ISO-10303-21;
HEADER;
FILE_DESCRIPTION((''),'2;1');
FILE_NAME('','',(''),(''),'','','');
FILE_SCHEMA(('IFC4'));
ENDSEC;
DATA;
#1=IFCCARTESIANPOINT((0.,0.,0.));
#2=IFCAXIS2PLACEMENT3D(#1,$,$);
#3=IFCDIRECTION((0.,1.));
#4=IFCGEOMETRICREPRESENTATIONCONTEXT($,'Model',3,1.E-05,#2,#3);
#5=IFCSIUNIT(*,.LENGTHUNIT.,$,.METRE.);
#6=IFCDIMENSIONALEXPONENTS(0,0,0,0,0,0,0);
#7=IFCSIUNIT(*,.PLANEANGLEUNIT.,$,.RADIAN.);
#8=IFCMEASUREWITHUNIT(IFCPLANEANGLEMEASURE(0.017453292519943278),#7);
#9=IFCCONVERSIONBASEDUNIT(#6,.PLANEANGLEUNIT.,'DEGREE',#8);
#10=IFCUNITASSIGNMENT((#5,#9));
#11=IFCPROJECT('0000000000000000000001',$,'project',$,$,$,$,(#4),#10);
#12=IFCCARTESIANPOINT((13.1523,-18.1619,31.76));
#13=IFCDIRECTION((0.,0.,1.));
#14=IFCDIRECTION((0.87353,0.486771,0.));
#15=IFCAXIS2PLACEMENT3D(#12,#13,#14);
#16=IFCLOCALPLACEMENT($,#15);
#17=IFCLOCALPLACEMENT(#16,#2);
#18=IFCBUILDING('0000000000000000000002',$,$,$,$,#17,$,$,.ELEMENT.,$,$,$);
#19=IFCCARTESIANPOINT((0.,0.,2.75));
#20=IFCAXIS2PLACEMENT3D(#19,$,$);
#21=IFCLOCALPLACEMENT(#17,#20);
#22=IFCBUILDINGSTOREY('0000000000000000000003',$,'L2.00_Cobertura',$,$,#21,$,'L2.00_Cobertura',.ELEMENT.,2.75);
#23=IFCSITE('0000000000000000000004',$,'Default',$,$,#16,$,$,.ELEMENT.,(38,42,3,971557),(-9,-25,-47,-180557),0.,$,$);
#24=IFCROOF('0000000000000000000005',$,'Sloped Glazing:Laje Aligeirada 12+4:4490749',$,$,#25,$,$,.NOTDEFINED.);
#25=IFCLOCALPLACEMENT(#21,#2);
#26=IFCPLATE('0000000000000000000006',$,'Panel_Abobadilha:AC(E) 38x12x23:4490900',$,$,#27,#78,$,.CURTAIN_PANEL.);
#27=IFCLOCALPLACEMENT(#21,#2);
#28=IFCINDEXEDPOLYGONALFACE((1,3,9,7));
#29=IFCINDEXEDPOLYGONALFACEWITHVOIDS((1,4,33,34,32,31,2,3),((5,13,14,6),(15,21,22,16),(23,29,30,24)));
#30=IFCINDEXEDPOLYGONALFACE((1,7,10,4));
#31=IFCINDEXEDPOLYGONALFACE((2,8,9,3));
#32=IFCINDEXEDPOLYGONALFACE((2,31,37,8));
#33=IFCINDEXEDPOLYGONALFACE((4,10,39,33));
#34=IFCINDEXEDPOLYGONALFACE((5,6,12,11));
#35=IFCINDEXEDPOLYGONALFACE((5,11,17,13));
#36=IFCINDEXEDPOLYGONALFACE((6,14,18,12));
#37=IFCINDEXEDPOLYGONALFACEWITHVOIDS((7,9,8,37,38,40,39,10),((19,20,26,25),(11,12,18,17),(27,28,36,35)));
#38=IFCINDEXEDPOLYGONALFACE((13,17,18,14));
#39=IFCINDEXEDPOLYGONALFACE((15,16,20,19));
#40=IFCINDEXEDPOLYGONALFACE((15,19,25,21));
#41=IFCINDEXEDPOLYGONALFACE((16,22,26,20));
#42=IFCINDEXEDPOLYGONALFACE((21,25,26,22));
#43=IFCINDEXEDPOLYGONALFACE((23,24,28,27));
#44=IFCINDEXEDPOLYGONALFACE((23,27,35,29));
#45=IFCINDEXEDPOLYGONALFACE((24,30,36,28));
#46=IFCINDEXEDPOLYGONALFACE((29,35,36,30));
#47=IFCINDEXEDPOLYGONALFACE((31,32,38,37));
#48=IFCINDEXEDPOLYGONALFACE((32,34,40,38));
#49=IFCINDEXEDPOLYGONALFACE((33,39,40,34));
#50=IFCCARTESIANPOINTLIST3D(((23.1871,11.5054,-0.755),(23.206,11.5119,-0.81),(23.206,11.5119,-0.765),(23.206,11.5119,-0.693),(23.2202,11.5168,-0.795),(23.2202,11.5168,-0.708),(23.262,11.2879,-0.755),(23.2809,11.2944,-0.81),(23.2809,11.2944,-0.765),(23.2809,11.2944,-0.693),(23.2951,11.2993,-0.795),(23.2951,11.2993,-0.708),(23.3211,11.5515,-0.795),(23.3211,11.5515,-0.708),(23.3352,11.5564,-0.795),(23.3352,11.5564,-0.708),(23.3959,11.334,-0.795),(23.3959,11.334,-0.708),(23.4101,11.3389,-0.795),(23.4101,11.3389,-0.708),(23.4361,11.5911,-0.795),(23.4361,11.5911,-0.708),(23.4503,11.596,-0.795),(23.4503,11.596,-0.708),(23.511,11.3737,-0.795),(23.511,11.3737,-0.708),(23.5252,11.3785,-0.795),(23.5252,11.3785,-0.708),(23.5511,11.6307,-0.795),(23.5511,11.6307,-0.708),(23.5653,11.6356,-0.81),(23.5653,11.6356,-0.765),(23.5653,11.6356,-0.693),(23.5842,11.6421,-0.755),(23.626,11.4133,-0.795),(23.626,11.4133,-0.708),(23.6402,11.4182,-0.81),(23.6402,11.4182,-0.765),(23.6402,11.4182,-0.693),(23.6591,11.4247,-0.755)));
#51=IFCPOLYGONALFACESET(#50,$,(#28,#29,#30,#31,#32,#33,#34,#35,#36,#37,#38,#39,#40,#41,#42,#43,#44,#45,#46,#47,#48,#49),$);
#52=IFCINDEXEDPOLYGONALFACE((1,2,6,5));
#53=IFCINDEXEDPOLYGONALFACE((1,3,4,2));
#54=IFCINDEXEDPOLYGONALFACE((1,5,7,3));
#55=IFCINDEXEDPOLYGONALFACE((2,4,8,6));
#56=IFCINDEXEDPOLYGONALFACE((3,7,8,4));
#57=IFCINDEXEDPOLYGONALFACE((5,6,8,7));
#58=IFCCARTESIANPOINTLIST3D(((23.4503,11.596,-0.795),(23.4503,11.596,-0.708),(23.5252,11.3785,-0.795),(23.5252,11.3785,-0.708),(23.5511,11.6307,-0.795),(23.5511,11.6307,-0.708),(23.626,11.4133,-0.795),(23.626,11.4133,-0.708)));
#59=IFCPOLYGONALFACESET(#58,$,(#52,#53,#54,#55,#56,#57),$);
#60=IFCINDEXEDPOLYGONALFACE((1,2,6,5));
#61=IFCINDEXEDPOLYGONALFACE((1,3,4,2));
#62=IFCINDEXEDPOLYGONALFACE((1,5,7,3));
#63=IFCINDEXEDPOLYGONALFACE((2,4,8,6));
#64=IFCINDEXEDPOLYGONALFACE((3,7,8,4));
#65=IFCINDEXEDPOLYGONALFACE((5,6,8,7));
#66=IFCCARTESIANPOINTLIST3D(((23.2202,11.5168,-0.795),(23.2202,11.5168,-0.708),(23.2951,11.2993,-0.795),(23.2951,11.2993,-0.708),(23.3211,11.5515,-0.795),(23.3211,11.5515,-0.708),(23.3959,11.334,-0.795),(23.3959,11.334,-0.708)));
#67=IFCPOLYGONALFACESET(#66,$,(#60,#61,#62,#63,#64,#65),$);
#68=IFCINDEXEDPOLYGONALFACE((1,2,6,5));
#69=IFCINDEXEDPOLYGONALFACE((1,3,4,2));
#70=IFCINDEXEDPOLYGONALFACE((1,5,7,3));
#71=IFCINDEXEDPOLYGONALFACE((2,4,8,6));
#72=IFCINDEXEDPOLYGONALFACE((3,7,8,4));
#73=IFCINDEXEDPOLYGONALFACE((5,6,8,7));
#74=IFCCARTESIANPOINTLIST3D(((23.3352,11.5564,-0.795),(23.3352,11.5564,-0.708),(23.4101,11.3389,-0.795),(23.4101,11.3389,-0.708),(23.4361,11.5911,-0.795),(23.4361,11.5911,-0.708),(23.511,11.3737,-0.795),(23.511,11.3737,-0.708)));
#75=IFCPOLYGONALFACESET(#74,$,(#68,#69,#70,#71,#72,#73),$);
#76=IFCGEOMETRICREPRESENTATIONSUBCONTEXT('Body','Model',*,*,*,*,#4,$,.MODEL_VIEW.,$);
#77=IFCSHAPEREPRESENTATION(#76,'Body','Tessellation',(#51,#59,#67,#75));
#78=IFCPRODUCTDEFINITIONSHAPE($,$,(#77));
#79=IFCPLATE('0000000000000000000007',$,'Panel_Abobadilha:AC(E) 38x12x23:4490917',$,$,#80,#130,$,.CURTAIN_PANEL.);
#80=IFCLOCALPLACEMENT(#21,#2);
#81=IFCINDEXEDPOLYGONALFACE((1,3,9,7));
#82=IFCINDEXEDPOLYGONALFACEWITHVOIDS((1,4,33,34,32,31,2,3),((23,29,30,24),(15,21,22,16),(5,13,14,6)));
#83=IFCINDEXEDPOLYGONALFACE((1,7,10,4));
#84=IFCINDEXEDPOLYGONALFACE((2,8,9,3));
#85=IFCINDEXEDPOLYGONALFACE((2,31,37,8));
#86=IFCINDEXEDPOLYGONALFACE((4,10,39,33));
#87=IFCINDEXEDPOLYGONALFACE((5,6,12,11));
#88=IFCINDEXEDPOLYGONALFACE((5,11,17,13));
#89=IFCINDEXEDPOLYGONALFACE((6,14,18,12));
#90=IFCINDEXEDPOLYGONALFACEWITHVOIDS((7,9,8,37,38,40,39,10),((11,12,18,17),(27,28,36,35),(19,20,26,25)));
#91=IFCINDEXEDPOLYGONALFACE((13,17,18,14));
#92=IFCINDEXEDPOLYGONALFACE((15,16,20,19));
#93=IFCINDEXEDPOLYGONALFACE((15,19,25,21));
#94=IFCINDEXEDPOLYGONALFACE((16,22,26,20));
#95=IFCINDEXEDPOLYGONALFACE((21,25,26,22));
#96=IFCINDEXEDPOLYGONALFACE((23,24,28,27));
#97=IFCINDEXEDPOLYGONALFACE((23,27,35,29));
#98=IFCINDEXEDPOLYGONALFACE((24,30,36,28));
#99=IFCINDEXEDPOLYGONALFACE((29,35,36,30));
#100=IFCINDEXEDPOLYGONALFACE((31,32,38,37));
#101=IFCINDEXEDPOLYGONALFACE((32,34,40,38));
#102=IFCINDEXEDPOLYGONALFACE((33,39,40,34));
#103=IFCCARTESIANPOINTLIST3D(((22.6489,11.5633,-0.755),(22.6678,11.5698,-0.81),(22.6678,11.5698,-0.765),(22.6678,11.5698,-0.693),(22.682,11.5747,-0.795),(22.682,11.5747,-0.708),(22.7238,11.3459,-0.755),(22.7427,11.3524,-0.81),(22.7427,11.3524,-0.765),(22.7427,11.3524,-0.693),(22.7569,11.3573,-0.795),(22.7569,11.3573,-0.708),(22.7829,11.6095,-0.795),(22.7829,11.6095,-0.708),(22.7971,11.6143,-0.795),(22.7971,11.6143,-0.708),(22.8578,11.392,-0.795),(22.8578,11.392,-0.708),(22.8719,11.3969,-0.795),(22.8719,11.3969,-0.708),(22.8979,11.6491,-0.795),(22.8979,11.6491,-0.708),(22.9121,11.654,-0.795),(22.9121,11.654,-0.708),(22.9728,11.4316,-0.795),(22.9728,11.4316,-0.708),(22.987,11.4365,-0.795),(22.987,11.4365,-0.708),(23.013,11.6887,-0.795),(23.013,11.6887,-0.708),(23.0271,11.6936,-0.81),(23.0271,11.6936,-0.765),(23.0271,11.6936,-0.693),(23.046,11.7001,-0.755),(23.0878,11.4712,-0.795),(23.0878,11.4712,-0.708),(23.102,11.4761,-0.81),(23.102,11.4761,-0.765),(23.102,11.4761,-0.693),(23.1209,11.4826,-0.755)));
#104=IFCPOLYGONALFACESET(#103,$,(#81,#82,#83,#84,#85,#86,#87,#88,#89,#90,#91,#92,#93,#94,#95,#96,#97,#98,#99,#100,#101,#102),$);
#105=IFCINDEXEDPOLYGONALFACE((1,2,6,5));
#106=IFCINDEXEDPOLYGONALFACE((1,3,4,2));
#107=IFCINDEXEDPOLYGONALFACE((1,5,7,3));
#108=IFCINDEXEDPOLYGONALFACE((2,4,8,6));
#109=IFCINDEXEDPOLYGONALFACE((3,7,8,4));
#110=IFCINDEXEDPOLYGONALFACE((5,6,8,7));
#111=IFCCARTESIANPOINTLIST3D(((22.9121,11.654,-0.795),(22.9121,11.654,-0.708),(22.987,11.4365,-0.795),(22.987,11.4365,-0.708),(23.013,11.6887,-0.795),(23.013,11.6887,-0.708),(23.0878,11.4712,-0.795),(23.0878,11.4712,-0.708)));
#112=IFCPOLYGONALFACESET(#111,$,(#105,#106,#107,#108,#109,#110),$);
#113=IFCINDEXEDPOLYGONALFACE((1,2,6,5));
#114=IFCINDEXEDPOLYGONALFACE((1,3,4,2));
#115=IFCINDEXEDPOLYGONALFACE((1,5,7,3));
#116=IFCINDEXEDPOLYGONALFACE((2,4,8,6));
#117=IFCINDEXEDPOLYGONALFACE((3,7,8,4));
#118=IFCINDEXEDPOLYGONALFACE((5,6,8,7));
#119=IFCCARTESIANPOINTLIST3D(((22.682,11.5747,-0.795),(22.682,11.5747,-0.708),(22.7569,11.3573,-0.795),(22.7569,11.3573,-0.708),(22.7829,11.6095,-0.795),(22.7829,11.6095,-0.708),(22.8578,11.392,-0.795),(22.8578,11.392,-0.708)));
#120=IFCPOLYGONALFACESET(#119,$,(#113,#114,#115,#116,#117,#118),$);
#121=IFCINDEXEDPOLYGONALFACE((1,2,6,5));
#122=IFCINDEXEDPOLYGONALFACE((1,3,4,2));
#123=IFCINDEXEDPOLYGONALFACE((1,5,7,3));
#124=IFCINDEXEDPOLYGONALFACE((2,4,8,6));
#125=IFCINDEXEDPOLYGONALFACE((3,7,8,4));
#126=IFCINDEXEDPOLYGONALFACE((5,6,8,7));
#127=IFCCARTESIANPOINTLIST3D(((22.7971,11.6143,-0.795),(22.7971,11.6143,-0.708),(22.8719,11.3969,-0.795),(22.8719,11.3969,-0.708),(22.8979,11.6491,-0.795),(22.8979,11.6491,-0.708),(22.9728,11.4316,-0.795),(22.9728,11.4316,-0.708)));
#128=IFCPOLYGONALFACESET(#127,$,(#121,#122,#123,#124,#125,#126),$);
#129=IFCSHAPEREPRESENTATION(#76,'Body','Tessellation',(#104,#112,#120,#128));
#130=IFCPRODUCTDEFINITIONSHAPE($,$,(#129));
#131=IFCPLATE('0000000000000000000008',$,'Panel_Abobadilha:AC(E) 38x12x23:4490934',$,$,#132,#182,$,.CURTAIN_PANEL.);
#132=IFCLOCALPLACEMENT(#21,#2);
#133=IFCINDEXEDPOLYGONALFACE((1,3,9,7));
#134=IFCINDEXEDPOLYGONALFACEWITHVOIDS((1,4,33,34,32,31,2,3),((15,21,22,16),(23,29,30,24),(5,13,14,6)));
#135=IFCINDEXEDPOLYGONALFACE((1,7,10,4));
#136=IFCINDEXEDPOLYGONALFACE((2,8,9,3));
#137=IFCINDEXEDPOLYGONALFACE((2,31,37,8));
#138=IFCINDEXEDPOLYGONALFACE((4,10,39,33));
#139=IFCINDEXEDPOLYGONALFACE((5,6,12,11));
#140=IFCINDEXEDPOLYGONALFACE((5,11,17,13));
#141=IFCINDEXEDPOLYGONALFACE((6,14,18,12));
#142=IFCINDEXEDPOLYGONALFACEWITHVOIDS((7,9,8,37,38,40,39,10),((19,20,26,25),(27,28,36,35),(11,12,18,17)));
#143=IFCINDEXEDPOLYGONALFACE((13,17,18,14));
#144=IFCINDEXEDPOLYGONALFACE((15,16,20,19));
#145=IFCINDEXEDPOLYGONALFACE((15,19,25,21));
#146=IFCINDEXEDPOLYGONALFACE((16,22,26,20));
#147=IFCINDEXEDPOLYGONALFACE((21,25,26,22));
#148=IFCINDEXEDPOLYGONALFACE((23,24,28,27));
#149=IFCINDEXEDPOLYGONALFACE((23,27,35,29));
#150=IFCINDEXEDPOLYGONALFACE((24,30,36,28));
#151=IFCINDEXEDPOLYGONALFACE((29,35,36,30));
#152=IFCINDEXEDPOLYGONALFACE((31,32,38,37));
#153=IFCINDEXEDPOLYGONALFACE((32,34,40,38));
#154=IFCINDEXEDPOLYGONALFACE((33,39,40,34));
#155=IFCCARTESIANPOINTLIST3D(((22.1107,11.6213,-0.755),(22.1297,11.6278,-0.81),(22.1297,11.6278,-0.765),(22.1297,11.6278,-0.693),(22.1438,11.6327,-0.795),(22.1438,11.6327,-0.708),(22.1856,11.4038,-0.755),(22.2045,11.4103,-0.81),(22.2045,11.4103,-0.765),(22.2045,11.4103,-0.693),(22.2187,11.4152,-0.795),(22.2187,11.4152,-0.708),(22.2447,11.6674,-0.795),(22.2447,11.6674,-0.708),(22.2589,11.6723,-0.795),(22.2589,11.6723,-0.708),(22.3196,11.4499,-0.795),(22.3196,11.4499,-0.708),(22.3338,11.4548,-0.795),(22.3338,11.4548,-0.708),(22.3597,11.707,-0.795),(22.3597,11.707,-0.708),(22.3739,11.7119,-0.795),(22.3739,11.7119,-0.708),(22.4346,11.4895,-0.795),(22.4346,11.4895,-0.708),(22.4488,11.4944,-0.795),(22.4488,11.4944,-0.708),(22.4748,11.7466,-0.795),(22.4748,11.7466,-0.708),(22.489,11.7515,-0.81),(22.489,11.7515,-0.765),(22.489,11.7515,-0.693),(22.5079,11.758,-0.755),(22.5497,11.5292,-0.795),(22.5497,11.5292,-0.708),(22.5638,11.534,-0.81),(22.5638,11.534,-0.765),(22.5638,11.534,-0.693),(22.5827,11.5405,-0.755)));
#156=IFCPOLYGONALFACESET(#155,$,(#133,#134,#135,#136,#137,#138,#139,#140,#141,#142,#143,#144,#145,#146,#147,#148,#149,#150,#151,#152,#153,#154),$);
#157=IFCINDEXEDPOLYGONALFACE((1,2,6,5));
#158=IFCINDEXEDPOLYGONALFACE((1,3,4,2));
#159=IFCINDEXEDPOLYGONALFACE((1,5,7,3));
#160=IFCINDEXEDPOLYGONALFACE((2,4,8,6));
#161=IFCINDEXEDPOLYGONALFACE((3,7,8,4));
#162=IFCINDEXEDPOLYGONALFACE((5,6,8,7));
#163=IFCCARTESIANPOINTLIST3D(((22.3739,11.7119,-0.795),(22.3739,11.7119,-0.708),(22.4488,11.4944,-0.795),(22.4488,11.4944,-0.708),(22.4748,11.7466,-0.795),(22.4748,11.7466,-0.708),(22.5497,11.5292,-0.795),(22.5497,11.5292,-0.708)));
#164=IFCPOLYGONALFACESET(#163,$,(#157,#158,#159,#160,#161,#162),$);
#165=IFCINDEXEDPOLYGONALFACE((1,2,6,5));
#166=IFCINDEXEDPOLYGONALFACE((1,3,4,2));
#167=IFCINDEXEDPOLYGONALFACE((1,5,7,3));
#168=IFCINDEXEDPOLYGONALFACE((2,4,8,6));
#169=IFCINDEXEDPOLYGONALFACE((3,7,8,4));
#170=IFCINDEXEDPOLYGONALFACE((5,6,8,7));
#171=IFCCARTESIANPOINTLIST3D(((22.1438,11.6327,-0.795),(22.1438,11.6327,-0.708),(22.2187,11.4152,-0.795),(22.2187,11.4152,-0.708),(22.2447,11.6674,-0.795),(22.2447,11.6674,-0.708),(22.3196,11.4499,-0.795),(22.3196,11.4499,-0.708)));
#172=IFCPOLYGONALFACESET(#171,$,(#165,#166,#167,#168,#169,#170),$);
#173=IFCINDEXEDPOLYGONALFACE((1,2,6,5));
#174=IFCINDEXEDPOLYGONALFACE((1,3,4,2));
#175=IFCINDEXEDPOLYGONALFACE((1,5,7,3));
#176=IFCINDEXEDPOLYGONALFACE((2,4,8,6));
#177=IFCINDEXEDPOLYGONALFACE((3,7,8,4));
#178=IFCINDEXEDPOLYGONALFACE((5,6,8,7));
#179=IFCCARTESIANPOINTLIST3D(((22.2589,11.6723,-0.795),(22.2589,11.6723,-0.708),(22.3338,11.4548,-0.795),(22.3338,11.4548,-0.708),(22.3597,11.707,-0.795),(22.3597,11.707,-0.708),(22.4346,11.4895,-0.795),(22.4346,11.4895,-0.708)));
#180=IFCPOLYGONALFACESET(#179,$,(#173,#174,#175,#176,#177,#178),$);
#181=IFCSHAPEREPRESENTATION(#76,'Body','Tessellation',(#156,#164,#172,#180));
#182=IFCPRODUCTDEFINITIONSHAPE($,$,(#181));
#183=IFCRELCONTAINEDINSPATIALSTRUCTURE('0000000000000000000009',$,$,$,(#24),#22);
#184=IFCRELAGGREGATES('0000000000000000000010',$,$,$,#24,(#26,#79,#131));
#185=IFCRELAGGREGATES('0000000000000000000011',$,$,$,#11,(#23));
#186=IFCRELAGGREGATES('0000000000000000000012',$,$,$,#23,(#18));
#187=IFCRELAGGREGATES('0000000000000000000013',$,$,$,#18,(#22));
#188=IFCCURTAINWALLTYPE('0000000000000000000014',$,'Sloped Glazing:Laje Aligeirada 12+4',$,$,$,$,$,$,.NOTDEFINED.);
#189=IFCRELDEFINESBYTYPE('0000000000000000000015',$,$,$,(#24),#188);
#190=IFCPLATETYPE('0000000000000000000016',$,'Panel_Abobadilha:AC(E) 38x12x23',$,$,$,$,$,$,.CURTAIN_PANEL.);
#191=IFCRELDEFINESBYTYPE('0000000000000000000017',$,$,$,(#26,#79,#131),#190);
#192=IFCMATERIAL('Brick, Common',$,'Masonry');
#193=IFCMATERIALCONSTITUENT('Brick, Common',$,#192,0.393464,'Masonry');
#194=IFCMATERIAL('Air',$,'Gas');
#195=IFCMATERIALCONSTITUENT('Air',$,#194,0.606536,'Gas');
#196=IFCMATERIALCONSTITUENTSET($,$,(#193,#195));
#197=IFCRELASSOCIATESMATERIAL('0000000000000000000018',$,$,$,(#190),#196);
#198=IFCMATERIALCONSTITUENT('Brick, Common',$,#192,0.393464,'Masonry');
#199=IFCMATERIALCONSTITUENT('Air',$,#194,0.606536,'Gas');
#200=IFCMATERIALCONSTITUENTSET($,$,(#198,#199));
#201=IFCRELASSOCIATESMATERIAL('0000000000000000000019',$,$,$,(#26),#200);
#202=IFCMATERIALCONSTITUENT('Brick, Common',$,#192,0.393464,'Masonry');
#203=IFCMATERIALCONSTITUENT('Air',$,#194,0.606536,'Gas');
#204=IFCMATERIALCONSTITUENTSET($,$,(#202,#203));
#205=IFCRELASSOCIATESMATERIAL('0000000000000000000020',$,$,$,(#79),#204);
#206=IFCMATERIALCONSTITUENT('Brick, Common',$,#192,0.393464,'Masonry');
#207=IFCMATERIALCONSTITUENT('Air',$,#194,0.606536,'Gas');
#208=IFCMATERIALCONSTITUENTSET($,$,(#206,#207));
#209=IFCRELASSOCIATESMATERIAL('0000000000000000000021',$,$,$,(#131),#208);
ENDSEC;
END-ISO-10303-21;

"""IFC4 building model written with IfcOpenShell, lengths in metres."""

from ifc_helpers import new_model, entity, si_unit, converted_unit, direction, frame, origin, place, context, subcontext, project, spatial, indexed_curve, outline, extrude, source, transform, mapped, material, constituent, constituent_set, type_object, type_shapes, element, aggregate, save


model = new_model("IFC4")

# Units and contexts
model_context = context("Model", 3, precision=1e-05, world=origin(), true_north=direction((0.0, 1.0)))
body_context = subcontext(model_context, "Body", "Model", "MODEL_VIEW")
ifc_project = project(units=[si_unit("LENGTHUNIT", "METRE"), converted_unit("PLANEANGLEUNIT", "DEGREE", entity("IfcPlaneAngleMeasure", 0.017453292519943278), si_unit("PLANEANGLEUNIT", "RADIAN"), dimensions=[0, 0, 0, 0, 0, 0, 0])], contexts=[model_context])

# Site, building, storey
site_placement = place(None, frame((13.1523, -18.1619, 31.76), z_axis=(0.0, 0.0, 1.0), x_axis=(0.87353, 0.486771, 0.0)))
site = spatial("IfcSite", under=ifc_project, at=site_placement, Name="Default", CompositionType="ELEMENT", RefLatitude=(38, 42, 3, 971557), RefLongitude=(-9, -25, -47, -180557), RefElevation=0.0)
building_placement = place(site_placement, origin())
building = spatial("IfcBuilding", under=site, at=building_placement, CompositionType="ELEMENT")
storey_placement = place(building_placement, frame((0.0, 0.0, 2.75)))
storey = spatial("IfcBuildingStorey", under=building, at=storey_placement, Name="L2.00_Cobertura", LongName="L2.00_Cobertura", CompositionType="ELEMENT", Elevation=2.75)

# Roof, plates
curtain_wall_type = type_object("IfcCurtainWallType", Name="Sloped Glazing:Laje Aligeirada 12+4", PredefinedType="NOTDEFINED")
roof_placement = place(storey_placement, frame((0.0, 0.0, -2.75)))
roof = element("IfcRoof", 1, at=roof_placement, inside=storey, type_object=curtain_wall_type, Name="Sloped Glazing:Laje Aligeirada 12+4:4490749", PredefinedType="NOTDEFINED")
ifc_material_1 = material(Name="Brick, Common", Category="Masonry")
ifc_material_2 = material(Name="Air", Category="Gas")
ifc_constituent_1 = constituent(ifc_material_1, Name="Brick, Common", Category="Masonry", fraction=0.393464)
ifc_constituent_2 = constituent(ifc_material_2, Name="Air", Category="Gas", fraction=0.606536)
ifc_constituent_set_1 = constituent_set(constituents=[ifc_constituent_1, ifc_constituent_2])
plate_type_1 = type_object("IfcPlateType", Name="Panel_Abobadilha:AC(E) 38x12x23", PredefinedType="CURTAIN_PANEL", material=ifc_constituent_set_1)
shared_shape_1 = source(origin(), body_context, "Body", "SweptSolid", [
    extrude(outline(indexed_curve([(-0.19, -0.0543), (0.19, -0.0543), (0.19, -0.0093), (0.21, 0.0007), (0.19, 0.0628), (-0.19, 0.0628), (-0.21, 0.0007), (-0.19, -0.0093), (-0.19, -0.0543)], self_intersect=False), holes=[indexed_curve([(-0.0683, 0.0477), (-0.0683, -0.0393), (-0.175, -0.0393), (-0.175, 0.0477), (-0.0683, 0.0477)], self_intersect=False), indexed_curve([(0.0533, 0.0477), (0.0533, -0.0393), (-0.0533, -0.0393), (-0.0533, 0.0477), (0.0533, 0.0477)], self_intersect=False), indexed_curve([(0.175, 0.0477), (0.175, -0.0393), (0.0683, -0.0393), (0.0683, 0.0477), (0.175, 0.0477)], self_intersect=False)]), frame((0.0, 0.0543, 0.0)), (0.0, 0.0, 1.0), 0.23),
    extrude(outline(indexed_curve([(-0.0533, -0.0435), (0.0533, -0.0435), (0.0533, 0.0435), (-0.0533, 0.0435), (-0.0533, -0.0435)], self_intersect=False)), frame((0.1217, 0.0585, 0.0), z_axis=(0.0, 0.0, 1.0), x_axis=(-1.0, 0.0, 0.0)), (0.0, 0.0, 1.0), 0.23),
    extrude(outline(indexed_curve([(-0.0533, -0.0435), (0.0533, -0.0435), (0.0533, 0.0435), (-0.0533, 0.0435), (-0.0533, -0.0435)], self_intersect=False)), frame((-0.1217, 0.0585, 0.0), z_axis=(0.0, 0.0, 1.0), x_axis=(-1.0, 0.0, 0.0)), (0.0, 0.0, 1.0), 0.23),
    extrude(outline(indexed_curve([(-0.0533, -0.0435), (0.0533, -0.0435), (0.0533, 0.0435), (-0.0533, 0.0435), (-0.0533, -0.0435)], self_intersect=False)), frame((0.0, 0.0585, 0.0), z_axis=(0.0, 0.0, 1.0), x_axis=(-1.0, 0.0, 0.0)), (0.0, 0.0, 1.0), 0.23),
])
type_shapes(plate_type_1, [shared_shape_1])
ifc_constituent_3 = constituent(ifc_material_1, Name="Brick, Common", Category="Masonry", fraction=0.393464)
ifc_constituent_4 = constituent(ifc_material_2, Name="Air", Category="Gas", fraction=0.606536)
ifc_constituent_set_2 = constituent_set(constituents=[ifc_constituent_3, ifc_constituent_4])
plate_1_placement = place(roof_placement, frame((23.3857, 11.5738, 1.94), z_axis=(0.325568, -0.945519, 0.0), x_axis=(0.945519, 0.325568, 0.0)))
plate_1 = element("IfcPlate", 2, at=plate_1_placement, type_object=plate_type_1, material=ifc_constituent_set_2, Name="Panel_Abobadilha:AC(E) 38x12x23:4490900", PredefinedType="CURTAIN_PANEL", context=body_context, shape_type="MappedRepresentation", body=[
    mapped(shared_shape_1, transform((0.0, 0.0, 0.0), scale=1.0)),
])
ifc_constituent_5 = constituent(ifc_material_1, Name="Brick, Common", Category="Masonry", fraction=0.393464)
ifc_constituent_6 = constituent(ifc_material_2, Name="Air", Category="Gas", fraction=0.606536)
ifc_constituent_set_3 = constituent_set(constituents=[ifc_constituent_5, ifc_constituent_6])
plate_2_placement = place(roof_placement, frame((22.8475, 11.6317, 1.94), z_axis=(0.325568, -0.945519, 0.0), x_axis=(0.945519, 0.325568, 0.0)))
plate_2 = element("IfcPlate", 3, at=plate_2_placement, type_object=plate_type_1, material=ifc_constituent_set_3, Name="Panel_Abobadilha:AC(E) 38x12x23:4490917", PredefinedType="CURTAIN_PANEL", context=body_context, shape_type="MappedRepresentation", body=[
    mapped(shared_shape_1, transform((0.0, 0.0, 0.0), scale=1.0)),
])
ifc_constituent_7 = constituent(ifc_material_1, Name="Brick, Common", Category="Masonry", fraction=0.393464)
ifc_constituent_8 = constituent(ifc_material_2, Name="Air", Category="Gas", fraction=0.606536)
ifc_constituent_set_4 = constituent_set(constituents=[ifc_constituent_7, ifc_constituent_8])
plate_3_placement = place(roof_placement, frame((22.3093, 11.6896, 1.94), z_axis=(0.325568, -0.945519, 0.0), x_axis=(0.945519, 0.325568, 0.0)))
plate_3 = element("IfcPlate", 4, at=plate_3_placement, type_object=plate_type_1, material=ifc_constituent_set_4, Name="Panel_Abobadilha:AC(E) 38x12x23:4490934", PredefinedType="CURTAIN_PANEL", context=body_context, shape_type="MappedRepresentation", body=[
    mapped(shared_shape_1, transform((0.0, 0.0, 0.0), scale=1.0)),
])
aggregate(roof, [plate_1, plate_2, plate_3])

save(model, "model.ifc")
